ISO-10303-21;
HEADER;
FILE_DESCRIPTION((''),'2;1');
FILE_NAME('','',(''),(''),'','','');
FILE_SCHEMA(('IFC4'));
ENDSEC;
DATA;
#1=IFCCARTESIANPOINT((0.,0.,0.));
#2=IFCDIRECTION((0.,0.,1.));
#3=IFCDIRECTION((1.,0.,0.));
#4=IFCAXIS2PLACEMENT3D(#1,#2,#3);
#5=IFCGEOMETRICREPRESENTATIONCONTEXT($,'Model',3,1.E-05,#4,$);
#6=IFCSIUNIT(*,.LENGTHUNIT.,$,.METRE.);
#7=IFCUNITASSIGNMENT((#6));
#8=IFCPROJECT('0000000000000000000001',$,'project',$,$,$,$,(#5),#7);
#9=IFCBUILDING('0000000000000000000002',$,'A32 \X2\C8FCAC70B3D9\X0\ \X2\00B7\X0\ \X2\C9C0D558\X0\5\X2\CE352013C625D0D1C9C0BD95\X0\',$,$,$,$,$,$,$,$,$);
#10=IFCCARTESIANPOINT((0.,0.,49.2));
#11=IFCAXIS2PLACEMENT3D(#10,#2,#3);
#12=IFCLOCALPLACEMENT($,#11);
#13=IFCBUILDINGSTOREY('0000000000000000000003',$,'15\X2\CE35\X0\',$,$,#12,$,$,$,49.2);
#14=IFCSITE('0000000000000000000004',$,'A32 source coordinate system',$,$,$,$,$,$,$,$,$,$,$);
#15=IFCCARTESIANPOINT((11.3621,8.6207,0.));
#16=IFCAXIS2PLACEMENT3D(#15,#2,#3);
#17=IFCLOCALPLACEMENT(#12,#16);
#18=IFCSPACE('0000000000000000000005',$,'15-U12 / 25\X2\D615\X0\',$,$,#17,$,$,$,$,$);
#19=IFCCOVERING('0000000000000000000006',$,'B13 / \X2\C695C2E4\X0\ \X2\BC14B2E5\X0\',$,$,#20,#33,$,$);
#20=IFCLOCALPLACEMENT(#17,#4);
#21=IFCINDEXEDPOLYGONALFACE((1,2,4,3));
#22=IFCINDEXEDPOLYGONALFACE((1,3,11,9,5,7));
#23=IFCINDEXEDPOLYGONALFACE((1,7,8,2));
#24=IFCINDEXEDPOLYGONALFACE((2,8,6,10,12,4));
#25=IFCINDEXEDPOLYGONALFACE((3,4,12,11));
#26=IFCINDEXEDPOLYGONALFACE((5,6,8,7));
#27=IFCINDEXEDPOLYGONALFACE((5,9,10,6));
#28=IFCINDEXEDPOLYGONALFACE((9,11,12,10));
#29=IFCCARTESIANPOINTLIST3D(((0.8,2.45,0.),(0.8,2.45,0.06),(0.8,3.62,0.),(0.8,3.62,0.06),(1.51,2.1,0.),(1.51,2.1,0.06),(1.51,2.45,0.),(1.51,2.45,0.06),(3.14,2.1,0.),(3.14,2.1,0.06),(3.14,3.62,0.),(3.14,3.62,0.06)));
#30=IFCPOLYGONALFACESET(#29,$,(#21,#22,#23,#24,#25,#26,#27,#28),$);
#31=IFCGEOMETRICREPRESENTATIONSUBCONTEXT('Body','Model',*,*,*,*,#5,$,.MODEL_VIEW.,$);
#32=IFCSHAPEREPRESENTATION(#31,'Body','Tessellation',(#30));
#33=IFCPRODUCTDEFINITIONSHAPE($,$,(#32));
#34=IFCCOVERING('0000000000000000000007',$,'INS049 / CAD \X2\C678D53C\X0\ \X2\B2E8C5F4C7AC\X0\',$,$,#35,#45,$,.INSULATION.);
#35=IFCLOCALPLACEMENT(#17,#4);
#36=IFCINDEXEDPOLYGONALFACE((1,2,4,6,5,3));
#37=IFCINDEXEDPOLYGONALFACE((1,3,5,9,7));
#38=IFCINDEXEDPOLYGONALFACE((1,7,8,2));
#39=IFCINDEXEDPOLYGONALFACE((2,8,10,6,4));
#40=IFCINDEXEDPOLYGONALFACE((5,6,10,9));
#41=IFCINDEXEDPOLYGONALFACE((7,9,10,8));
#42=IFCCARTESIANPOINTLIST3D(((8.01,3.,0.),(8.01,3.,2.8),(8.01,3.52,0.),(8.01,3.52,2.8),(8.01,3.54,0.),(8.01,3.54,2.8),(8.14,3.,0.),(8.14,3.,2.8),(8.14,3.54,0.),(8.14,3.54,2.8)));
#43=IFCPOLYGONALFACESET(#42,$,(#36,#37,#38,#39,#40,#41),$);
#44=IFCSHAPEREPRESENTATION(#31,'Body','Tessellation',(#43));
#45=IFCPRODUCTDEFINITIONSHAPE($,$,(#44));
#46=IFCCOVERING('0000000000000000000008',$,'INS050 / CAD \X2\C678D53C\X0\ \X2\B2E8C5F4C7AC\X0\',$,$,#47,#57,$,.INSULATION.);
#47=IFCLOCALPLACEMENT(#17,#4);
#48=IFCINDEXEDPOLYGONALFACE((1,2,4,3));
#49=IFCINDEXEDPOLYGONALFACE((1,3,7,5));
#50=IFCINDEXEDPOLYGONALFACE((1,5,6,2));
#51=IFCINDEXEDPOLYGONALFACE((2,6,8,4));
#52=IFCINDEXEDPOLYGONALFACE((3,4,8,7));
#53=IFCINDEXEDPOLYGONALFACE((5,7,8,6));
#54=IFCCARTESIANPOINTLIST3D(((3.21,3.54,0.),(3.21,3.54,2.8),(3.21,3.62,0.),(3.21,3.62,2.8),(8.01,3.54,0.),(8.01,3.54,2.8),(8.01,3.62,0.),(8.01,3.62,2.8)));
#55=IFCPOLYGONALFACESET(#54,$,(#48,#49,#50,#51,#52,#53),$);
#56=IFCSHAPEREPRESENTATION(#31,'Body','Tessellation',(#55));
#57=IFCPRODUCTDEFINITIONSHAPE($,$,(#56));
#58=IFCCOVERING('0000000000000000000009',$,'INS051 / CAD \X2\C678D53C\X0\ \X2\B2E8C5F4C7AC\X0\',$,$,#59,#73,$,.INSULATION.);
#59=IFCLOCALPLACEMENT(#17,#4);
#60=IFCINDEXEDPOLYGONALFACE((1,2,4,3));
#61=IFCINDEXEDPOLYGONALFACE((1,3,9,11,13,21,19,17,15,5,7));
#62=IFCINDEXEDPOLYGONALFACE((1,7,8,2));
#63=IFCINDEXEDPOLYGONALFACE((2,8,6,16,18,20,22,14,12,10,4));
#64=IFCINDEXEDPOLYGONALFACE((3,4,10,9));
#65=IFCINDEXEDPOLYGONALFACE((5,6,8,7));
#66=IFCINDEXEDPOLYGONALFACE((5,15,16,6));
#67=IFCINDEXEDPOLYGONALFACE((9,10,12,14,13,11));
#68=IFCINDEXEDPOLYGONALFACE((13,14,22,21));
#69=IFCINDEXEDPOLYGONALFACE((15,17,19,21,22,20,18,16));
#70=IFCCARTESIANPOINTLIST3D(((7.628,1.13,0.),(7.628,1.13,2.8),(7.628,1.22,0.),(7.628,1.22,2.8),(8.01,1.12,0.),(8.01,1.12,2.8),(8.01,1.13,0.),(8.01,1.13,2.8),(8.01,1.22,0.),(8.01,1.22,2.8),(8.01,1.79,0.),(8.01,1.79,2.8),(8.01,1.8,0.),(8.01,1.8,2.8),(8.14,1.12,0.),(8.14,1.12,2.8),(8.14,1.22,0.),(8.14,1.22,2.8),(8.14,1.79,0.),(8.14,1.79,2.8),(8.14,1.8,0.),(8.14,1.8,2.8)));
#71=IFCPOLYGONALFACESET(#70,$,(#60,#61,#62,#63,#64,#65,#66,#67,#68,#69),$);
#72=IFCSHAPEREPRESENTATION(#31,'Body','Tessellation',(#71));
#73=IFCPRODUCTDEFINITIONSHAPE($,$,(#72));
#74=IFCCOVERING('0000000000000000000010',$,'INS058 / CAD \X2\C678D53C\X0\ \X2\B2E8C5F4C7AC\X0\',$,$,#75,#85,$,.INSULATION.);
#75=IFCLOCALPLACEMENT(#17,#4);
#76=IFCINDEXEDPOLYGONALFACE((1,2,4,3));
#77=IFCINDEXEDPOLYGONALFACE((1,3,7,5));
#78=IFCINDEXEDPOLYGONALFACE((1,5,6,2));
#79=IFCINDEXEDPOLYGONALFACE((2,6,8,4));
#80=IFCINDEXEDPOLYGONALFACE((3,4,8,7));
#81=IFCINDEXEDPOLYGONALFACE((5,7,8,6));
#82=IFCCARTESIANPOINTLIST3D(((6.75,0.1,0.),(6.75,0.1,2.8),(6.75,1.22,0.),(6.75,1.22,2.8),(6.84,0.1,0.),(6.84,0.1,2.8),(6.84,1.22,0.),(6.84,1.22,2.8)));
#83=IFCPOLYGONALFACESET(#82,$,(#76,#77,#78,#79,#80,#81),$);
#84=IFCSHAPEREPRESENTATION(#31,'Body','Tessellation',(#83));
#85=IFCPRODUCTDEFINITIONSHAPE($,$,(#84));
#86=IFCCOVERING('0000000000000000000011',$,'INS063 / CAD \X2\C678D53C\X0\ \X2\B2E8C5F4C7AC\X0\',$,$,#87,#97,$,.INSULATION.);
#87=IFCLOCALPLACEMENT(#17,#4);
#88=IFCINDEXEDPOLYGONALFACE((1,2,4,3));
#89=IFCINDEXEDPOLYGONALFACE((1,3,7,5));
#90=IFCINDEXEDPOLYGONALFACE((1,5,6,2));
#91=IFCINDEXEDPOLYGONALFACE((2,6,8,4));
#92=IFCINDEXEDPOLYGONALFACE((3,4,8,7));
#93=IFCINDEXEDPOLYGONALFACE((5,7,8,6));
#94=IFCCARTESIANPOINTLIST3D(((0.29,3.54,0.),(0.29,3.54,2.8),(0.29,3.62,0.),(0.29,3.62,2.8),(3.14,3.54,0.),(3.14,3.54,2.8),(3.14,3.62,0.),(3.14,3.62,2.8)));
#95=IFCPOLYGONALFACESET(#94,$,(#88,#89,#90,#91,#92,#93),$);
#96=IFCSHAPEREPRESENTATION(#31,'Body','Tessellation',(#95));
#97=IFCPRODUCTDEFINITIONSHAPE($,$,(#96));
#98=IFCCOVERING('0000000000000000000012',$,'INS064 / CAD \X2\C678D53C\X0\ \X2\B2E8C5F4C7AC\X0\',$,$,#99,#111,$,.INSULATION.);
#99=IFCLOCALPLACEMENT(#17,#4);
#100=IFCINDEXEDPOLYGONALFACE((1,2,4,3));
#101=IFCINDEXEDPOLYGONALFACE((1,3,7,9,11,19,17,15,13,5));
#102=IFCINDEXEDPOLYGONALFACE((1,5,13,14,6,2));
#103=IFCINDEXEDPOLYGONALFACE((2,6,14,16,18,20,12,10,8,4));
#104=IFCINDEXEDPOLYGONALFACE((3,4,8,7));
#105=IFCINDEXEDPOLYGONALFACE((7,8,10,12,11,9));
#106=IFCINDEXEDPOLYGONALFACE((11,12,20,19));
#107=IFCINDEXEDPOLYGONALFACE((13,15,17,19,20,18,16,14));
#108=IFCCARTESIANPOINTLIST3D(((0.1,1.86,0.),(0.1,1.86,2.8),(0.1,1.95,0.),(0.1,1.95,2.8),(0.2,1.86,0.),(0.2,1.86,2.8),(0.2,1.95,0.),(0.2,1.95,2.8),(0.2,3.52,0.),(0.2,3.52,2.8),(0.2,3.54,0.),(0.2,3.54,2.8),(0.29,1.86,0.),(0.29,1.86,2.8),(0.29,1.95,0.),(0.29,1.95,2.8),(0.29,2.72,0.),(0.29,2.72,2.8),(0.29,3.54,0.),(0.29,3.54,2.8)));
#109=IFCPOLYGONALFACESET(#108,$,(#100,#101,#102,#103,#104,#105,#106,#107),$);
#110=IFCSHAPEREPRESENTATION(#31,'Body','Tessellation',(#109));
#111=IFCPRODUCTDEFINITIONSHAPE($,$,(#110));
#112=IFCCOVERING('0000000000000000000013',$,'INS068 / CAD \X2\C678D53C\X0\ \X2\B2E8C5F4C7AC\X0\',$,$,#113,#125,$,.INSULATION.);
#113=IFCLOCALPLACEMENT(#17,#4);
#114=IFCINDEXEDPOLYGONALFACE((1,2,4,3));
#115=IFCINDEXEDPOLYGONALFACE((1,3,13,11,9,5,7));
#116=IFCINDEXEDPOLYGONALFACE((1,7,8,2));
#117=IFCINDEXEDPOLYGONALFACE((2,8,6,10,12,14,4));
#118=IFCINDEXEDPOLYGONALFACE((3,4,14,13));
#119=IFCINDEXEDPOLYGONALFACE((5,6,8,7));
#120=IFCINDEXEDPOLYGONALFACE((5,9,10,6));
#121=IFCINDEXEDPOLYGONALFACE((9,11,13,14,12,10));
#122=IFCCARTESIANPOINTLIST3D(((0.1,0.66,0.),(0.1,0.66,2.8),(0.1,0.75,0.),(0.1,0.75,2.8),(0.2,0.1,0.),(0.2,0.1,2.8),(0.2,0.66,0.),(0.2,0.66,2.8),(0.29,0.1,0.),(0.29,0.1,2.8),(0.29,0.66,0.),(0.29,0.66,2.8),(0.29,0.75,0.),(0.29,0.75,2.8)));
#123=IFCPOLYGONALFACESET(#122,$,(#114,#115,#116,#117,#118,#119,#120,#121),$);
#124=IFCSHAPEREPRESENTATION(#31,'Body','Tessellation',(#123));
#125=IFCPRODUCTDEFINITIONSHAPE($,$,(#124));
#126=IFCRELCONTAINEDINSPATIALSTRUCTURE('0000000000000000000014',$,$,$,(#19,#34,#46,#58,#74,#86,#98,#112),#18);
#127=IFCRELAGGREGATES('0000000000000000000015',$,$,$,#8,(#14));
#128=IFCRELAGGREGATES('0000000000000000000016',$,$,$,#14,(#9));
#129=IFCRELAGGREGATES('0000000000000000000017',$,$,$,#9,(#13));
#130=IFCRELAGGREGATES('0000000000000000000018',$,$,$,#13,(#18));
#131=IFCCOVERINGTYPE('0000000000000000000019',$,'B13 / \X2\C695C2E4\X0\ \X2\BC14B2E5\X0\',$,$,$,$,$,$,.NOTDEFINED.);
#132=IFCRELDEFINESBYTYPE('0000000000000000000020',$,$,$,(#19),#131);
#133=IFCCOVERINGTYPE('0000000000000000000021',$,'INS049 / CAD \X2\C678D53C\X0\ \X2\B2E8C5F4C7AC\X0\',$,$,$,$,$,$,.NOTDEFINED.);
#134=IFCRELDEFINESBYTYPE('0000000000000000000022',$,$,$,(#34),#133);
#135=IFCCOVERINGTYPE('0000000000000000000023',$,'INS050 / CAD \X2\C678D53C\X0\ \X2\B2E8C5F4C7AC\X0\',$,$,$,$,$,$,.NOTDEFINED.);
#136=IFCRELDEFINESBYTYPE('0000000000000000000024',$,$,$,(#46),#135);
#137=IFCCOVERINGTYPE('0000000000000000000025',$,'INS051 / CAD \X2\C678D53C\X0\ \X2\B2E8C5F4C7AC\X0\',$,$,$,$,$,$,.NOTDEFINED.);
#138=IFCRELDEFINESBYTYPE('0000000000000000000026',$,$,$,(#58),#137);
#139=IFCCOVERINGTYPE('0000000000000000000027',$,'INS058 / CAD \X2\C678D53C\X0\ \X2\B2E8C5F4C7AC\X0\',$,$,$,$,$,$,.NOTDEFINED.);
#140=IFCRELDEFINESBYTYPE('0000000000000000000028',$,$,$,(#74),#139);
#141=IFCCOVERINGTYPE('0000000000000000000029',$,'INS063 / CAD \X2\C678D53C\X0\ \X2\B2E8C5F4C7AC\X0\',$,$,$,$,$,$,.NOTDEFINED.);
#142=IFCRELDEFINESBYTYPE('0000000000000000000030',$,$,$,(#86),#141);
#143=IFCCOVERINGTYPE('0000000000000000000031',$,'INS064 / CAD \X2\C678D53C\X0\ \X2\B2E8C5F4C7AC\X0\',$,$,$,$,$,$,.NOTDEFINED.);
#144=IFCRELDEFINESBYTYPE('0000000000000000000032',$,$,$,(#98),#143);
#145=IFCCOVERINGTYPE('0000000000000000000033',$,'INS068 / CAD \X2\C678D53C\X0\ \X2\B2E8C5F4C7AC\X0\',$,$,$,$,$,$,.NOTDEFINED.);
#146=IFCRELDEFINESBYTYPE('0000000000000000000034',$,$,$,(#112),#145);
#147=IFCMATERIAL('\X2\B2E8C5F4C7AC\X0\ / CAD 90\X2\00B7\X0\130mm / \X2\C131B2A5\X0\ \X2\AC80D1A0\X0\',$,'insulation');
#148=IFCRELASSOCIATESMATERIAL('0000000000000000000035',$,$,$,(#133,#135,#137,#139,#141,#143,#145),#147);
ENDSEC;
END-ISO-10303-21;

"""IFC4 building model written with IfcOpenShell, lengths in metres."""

from ifc_helpers import new_model, si_unit, frame, origin, origin_with_axes, place, context, subcontext, project, spatial, polyline, outline, extrude, source, transform, mapped, material, type_object, type_shapes, element, save


model = new_model("IFC4")

# Units and contexts
model_context = context("Model", 3, precision=1e-05, world=origin_with_axes())
body_context = subcontext(model_context, "Body", "Model", "MODEL_VIEW")
ifc_project = project(units=[si_unit("LENGTHUNIT", "METRE")], contexts=[model_context])

# Site, building, storey
storey_placement = place(None, frame((0.0, 0.0, 49.2), z_axis=(0.0, 0.0, 1.0), x_axis=(1.0, 0.0, 0.0)))
space_1_placement = place(storey_placement, frame((11.3621, 8.6207, 0.0), z_axis=(0.0, 0.0, 1.0), x_axis=(1.0, 0.0, 0.0)))
site = spatial("IfcSite", under=ifc_project, Name="A32 source coordinate system")
building = spatial("IfcBuilding", under=site, Name="A32 주거동 · 지하5층–옥탑지붕")
storey = spatial("IfcBuildingStorey", under=building, at=storey_placement, Name="15층", Elevation=49.2)

# Shared definitions
space_1 = spatial("IfcSpace", under=storey, at=space_1_placement, Name="15-U12 / 25형")

# Coverings
covering_type_1 = type_object("IfcCoveringType", Name="B13 / 욕실 바닥", PredefinedType="NOTDEFINED")
shared_shape_1 = source(origin(), body_context, "Body", "SweptSolid", [
    extrude(outline(polyline([(3.14, 2.1), (1.51, 2.1), (1.51, 2.45), (0.8, 2.45), (0.8, 3.62), (3.14, 3.62), (3.14, 2.1)])), origin(), (0.0, 0.0, 1.0), 0.06),
])
type_shapes(covering_type_1, [shared_shape_1])
covering_1_placement = place(space_1_placement, origin_with_axes())
element("IfcCovering", 1, at=covering_1_placement, inside=space_1, type_object=covering_type_1, Name="B13 / 욕실 바닥", context=body_context, shape_type="MappedRepresentation", body=[
    mapped(shared_shape_1, transform((0.0, 0.0, 0.0), scale=1.0)),
])
ifc_material = material(Name="단열재 / CAD 90·130mm / 성능 검토", Category="insulation")
covering_type_2 = type_object("IfcCoveringType", Name="INS049 / CAD 외피 단열재", PredefinedType="NOTDEFINED", material=ifc_material)
shared_shape_2 = source(origin(), body_context, "Body", "SweptSolid", [
    extrude(outline(polyline([(8.01, 3.54), (8.14, 3.54), (8.14, 3.0), (8.01, 3.0), (8.01, 3.52), (8.01, 3.54)])), origin(), (0.0, 0.0, 1.0), 2.8),
])
type_shapes(covering_type_2, [shared_shape_2])
covering_2_placement = place(space_1_placement, origin_with_axes())
element("IfcCovering", 2, at=covering_2_placement, inside=space_1, type_object=covering_type_2, Name="INS049 / CAD 외피 단열재", PredefinedType="INSULATION", context=body_context, shape_type="MappedRepresentation", body=[
    mapped(shared_shape_2, transform((0.0, 0.0, 0.0), scale=1.0)),
])
covering_type_3 = type_object("IfcCoveringType", Name="INS050 / CAD 외피 단열재", PredefinedType="NOTDEFINED", material=ifc_material)
shared_shape_3 = source(origin(), body_context, "Body", "SweptSolid", [
    extrude(outline(polyline([(8.01, 3.54), (3.21, 3.54), (3.21, 3.62), (8.01, 3.62), (8.01, 3.54)])), origin(), (0.0, 0.0, 1.0), 2.8),
])
type_shapes(covering_type_3, [shared_shape_3])
covering_3_placement = place(space_1_placement, origin_with_axes())
element("IfcCovering", 3, at=covering_3_placement, inside=space_1, type_object=covering_type_3, Name="INS050 / CAD 외피 단열재", PredefinedType="INSULATION", context=body_context, shape_type="MappedRepresentation", body=[
    mapped(shared_shape_3, transform((0.0, 0.0, 0.0), scale=1.0)),
])
covering_type_4 = type_object("IfcCoveringType", Name="INS051 / CAD 외피 단열재", PredefinedType="NOTDEFINED", material=ifc_material)
shared_shape_4 = source(origin(), body_context, "Body", "SweptSolid", [
    extrude(outline(polyline([(8.14, 1.12), (8.01, 1.12), (8.01, 1.13), (7.628, 1.13), (7.628, 1.22), (8.01, 1.22), (8.01, 1.79), (8.01, 1.8), (8.14, 1.8), (8.14, 1.79), (8.14, 1.22), (8.14, 1.12)])), origin(), (0.0, 0.0, 1.0), 2.8),
])
type_shapes(covering_type_4, [shared_shape_4])
covering_4_placement = place(space_1_placement, origin_with_axes())
element("IfcCovering", 4, at=covering_4_placement, inside=space_1, type_object=covering_type_4, Name="INS051 / CAD 외피 단열재", PredefinedType="INSULATION", context=body_context, shape_type="MappedRepresentation", body=[
    mapped(shared_shape_4, transform((0.0, 0.0, 0.0), scale=1.0)),
])
covering_type_5 = type_object("IfcCoveringType", Name="INS058 / CAD 외피 단열재", PredefinedType="NOTDEFINED", material=ifc_material)
shared_shape_5 = source(origin(), body_context, "Body", "SweptSolid", [
    extrude(outline(polyline([(6.75, 0.1), (6.75, 1.22), (6.84, 1.22), (6.84, 0.1), (6.75, 0.1)])), origin(), (0.0, 0.0, 1.0), 2.8),
])
type_shapes(covering_type_5, [shared_shape_5])
covering_5_placement = place(space_1_placement, origin_with_axes())
element("IfcCovering", 5, at=covering_5_placement, inside=space_1, type_object=covering_type_5, Name="INS058 / CAD 외피 단열재", PredefinedType="INSULATION", context=body_context, shape_type="MappedRepresentation", body=[
    mapped(shared_shape_5, transform((0.0, 0.0, 0.0), scale=1.0)),
])
covering_type_6 = type_object("IfcCoveringType", Name="INS063 / CAD 외피 단열재", PredefinedType="NOTDEFINED", material=ifc_material)
shared_shape_6 = source(origin(), body_context, "Body", "SweptSolid", [
    extrude(outline(polyline([(0.29, 3.54), (0.29, 3.62), (3.14, 3.62), (3.14, 3.54), (0.29, 3.54)])), origin(), (0.0, 0.0, 1.0), 2.8),
])
type_shapes(covering_type_6, [shared_shape_6])
covering_6_placement = place(space_1_placement, origin_with_axes())
element("IfcCovering", 6, at=covering_6_placement, inside=space_1, type_object=covering_type_6, Name="INS063 / CAD 외피 단열재", PredefinedType="INSULATION", context=body_context, shape_type="MappedRepresentation", body=[
    mapped(shared_shape_6, transform((0.0, 0.0, 0.0), scale=1.0)),
])
covering_type_7 = type_object("IfcCoveringType", Name="INS064 / CAD 외피 단열재", PredefinedType="NOTDEFINED", material=ifc_material)
shared_shape_7 = source(origin(), body_context, "Body", "SweptSolid", [
    extrude(outline(polyline([(0.1, 1.86), (0.1, 1.95), (0.2, 1.95), (0.2, 3.52), (0.2, 3.54), (0.29, 3.54), (0.29, 2.72), (0.29, 1.95), (0.29, 1.86), (0.2, 1.86), (0.1, 1.86)])), origin(), (0.0, 0.0, 1.0), 2.8),
])
type_shapes(covering_type_7, [shared_shape_7])
covering_7_placement = place(space_1_placement, origin_with_axes())
element("IfcCovering", 7, at=covering_7_placement, inside=space_1, type_object=covering_type_7, Name="INS064 / CAD 외피 단열재", PredefinedType="INSULATION", context=body_context, shape_type="MappedRepresentation", body=[
    mapped(shared_shape_7, transform((0.0, 0.0, 0.0), scale=1.0)),
])
covering_type_8 = type_object("IfcCoveringType", Name="INS068 / CAD 외피 단열재", PredefinedType="NOTDEFINED", material=ifc_material)
shared_shape_8 = source(origin(), body_context, "Body", "SweptSolid", [
    extrude(outline(polyline([(0.2, 0.1), (0.2, 0.66), (0.1, 0.66), (0.1, 0.75), (0.29, 0.75), (0.29, 0.66), (0.29, 0.1), (0.2, 0.1)])), origin(), (0.0, 0.0, 1.0), 2.8),
])
type_shapes(covering_type_8, [shared_shape_8])
covering_8_placement = place(space_1_placement, origin_with_axes())
element("IfcCovering", 8, at=covering_8_placement, inside=space_1, type_object=covering_type_8, Name="INS068 / CAD 외피 단열재", PredefinedType="INSULATION", context=body_context, shape_type="MappedRepresentation", body=[
    mapped(shared_shape_8, transform((0.0, 0.0, 0.0), scale=1.0)),
])

save(model, "model.ifc")
